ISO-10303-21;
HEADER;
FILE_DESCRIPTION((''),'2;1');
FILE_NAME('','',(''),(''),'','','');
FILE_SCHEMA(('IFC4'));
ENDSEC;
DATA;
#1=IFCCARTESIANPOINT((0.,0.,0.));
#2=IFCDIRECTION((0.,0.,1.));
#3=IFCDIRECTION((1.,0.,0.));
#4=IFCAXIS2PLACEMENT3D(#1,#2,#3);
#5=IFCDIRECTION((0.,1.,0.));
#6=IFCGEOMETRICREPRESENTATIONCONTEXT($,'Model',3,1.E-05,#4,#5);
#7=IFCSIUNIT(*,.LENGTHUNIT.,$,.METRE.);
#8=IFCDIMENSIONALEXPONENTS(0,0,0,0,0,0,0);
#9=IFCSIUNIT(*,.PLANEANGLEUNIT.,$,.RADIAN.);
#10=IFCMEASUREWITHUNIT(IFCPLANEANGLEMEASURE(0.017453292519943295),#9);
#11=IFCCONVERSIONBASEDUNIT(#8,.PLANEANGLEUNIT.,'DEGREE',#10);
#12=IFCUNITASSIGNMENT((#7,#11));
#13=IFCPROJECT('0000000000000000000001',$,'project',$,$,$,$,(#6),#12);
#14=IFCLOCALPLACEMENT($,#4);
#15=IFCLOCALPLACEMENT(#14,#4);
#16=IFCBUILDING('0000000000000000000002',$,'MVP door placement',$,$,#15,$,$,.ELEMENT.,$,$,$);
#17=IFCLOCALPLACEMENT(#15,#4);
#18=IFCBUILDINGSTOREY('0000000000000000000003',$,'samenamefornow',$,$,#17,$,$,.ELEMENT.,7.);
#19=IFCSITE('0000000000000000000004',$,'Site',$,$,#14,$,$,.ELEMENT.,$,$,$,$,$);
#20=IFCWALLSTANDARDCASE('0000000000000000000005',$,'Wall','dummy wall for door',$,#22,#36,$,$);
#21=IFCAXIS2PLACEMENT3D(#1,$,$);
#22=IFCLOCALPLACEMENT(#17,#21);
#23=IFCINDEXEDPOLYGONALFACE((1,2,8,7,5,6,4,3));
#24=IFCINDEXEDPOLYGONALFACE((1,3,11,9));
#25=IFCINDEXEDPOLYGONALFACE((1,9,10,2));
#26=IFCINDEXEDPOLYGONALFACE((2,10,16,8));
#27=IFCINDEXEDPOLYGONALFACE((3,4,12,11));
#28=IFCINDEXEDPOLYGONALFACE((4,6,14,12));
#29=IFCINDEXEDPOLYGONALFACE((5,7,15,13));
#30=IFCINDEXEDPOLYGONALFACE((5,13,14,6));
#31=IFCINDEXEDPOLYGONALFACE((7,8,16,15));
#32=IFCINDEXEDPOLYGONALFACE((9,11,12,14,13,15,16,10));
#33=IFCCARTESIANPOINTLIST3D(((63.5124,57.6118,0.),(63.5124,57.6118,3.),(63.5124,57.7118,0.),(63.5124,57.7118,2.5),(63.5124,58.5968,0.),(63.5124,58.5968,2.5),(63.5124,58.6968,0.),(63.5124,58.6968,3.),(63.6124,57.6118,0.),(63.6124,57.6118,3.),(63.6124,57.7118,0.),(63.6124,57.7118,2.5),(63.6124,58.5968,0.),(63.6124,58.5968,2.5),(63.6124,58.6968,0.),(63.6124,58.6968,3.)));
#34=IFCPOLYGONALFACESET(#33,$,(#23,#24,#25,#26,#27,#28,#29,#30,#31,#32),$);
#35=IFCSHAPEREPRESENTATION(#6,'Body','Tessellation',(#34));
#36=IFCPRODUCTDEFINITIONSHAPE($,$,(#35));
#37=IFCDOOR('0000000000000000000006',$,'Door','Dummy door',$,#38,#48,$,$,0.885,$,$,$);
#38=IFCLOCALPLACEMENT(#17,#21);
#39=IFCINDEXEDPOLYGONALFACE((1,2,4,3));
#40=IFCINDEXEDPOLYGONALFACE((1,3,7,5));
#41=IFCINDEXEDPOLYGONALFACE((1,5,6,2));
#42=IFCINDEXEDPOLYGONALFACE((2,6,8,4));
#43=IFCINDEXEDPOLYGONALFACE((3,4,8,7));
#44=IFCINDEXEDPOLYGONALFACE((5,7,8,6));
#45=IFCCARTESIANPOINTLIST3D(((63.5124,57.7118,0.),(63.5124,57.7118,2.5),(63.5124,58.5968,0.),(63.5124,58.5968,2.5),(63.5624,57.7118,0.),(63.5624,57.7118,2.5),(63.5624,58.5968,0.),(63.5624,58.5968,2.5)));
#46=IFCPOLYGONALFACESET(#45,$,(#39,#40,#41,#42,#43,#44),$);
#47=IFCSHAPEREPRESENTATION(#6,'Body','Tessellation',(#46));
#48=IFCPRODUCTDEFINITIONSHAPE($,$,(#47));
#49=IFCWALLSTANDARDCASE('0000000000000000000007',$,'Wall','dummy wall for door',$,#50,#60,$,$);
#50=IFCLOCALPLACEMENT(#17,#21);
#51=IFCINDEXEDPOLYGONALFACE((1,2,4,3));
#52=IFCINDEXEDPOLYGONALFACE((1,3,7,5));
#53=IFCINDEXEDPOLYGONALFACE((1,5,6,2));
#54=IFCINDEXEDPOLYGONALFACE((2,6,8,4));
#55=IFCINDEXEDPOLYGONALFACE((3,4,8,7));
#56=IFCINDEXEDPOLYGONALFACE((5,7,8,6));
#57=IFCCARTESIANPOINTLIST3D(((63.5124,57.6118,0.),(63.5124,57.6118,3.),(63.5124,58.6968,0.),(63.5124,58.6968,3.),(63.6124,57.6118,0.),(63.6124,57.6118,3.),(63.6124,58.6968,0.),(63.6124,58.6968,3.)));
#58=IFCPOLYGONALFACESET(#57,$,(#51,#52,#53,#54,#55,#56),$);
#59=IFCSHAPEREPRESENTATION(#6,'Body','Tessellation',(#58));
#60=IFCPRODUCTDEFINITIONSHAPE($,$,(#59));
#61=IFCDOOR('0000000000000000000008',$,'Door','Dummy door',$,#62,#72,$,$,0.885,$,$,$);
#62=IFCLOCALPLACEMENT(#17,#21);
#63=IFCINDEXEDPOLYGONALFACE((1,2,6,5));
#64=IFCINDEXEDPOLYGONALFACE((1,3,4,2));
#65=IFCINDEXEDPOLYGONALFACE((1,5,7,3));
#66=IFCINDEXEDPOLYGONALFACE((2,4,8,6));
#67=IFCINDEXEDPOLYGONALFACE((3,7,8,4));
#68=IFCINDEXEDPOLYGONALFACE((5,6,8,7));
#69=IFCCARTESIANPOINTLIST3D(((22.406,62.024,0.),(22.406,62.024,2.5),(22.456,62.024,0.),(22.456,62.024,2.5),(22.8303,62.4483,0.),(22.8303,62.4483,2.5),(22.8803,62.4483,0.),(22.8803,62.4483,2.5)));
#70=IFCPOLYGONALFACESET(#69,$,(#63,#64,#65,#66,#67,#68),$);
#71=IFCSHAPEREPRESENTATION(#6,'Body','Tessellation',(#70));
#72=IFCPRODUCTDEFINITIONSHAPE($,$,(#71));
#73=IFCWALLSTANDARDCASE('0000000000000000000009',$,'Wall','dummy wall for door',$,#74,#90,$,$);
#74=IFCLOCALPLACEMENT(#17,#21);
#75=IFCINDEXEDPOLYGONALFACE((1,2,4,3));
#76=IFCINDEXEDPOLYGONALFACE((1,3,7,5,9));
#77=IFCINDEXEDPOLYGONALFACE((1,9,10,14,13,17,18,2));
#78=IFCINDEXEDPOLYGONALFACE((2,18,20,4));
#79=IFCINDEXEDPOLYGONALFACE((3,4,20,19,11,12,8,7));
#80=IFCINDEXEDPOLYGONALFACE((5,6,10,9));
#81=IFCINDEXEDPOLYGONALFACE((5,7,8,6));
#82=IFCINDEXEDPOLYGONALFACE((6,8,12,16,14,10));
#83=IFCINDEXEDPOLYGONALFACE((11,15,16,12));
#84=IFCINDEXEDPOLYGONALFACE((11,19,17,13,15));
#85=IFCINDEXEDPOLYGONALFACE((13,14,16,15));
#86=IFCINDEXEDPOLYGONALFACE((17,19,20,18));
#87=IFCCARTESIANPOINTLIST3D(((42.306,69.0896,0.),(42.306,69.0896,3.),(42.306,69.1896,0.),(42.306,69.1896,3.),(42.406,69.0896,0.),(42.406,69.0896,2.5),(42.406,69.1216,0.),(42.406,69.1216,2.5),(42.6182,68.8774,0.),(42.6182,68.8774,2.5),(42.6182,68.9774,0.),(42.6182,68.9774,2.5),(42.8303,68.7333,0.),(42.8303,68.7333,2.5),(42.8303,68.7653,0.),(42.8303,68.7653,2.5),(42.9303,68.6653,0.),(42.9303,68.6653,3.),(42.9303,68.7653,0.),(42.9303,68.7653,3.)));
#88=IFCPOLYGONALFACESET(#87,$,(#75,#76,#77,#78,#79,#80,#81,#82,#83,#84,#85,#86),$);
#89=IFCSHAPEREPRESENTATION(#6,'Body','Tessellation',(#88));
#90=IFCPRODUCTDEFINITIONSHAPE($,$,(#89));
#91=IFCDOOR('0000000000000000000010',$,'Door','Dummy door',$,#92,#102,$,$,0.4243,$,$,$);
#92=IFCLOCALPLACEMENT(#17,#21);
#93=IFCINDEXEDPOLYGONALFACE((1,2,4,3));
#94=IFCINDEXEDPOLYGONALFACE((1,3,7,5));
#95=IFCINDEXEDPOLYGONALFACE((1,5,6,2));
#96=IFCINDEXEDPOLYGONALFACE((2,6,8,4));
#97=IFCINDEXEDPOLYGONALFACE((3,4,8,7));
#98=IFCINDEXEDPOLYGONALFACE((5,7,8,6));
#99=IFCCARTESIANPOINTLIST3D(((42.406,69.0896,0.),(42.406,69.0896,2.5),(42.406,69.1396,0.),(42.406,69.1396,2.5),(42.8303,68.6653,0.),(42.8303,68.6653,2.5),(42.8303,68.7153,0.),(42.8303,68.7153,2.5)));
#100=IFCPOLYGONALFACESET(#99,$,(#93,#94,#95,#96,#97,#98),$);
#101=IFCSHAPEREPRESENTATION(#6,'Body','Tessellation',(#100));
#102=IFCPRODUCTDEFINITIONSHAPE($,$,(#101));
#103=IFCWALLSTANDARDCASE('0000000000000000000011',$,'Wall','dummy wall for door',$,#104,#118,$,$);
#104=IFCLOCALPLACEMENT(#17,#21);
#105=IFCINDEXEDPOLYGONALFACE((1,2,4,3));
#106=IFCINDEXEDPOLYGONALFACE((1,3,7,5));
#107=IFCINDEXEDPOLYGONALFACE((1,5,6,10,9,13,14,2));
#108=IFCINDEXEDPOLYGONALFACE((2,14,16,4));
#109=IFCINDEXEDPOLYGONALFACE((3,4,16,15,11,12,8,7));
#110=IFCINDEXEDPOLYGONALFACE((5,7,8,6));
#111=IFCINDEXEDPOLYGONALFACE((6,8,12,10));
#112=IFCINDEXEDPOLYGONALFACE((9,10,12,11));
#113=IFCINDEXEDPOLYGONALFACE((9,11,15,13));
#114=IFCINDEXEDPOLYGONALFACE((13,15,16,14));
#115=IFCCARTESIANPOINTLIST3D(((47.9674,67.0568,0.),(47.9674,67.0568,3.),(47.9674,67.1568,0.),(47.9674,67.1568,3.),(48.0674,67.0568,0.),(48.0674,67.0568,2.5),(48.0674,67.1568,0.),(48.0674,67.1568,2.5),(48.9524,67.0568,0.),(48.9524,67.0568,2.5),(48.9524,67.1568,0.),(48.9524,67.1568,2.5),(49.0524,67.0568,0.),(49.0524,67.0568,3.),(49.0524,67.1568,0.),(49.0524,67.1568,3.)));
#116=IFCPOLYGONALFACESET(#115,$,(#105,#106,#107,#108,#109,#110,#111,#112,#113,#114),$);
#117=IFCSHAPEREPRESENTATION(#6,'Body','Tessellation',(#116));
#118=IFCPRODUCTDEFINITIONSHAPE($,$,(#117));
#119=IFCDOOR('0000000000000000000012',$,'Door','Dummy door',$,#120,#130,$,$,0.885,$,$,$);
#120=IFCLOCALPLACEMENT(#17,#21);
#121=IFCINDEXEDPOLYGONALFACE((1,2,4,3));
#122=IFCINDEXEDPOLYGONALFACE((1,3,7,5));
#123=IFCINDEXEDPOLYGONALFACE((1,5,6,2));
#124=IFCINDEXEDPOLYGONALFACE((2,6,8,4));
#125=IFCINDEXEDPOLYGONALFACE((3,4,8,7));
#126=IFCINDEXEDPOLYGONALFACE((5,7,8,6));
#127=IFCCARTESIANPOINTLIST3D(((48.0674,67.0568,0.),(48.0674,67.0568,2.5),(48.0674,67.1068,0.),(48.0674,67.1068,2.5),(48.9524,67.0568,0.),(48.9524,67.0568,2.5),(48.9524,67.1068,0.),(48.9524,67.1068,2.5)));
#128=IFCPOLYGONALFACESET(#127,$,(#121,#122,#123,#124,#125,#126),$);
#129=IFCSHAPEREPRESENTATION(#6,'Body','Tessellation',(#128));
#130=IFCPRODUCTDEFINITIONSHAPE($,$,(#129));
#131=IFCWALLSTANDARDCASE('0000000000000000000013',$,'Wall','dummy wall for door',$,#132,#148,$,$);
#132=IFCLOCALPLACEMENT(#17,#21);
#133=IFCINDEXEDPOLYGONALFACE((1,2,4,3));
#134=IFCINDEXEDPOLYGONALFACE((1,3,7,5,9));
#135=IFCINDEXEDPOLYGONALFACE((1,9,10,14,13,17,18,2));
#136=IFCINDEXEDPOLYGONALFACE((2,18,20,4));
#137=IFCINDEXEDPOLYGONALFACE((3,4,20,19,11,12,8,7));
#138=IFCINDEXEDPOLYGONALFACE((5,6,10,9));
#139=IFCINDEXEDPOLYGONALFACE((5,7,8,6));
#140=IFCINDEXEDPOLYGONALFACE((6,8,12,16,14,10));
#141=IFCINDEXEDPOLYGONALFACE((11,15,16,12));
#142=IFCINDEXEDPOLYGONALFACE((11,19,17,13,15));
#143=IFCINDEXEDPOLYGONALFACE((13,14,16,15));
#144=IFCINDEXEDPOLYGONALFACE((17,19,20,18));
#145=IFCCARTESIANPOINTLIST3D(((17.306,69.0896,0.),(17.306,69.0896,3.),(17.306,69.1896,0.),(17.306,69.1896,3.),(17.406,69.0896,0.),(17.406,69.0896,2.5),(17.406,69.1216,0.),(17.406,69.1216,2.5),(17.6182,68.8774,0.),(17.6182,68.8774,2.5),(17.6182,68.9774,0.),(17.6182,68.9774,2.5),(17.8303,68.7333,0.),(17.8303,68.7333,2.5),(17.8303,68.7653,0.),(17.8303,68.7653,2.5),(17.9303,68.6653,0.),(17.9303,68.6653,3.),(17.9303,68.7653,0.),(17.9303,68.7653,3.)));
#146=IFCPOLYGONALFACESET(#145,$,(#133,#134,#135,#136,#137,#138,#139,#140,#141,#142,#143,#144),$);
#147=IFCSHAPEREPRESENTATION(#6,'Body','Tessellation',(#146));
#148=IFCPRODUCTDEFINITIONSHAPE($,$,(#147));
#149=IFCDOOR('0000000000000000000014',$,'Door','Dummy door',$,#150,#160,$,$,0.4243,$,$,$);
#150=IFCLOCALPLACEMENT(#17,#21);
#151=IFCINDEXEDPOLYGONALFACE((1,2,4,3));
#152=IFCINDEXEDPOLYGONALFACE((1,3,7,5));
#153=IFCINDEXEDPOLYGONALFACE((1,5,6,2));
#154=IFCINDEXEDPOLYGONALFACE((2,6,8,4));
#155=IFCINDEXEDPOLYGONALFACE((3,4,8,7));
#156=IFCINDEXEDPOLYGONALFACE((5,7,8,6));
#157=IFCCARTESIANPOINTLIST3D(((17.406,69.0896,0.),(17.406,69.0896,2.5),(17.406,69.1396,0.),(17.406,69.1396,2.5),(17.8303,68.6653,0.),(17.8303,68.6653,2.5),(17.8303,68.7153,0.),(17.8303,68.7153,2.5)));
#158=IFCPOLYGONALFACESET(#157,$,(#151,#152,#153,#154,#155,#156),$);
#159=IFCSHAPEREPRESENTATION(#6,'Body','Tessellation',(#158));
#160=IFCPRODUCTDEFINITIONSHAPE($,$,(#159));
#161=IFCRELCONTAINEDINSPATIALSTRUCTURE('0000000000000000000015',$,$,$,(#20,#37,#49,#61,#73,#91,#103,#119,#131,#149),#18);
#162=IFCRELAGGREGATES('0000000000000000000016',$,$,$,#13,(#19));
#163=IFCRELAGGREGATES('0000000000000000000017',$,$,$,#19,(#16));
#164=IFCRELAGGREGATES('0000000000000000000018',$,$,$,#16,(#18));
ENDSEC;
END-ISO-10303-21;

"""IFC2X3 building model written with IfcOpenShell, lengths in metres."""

from ifc_helpers import new_model, entity, si_unit, converted_unit, direction, origin_with_axes, place, context, project, spatial, polyline, outline, extrude, element, fill, save


model = new_model("IFC2X3")

# Units and contexts
model_context = context("Model", 3, precision=1e-05, world=origin_with_axes(), true_north=direction((0.0, 1.0, 0.0)))
ifc_project = project(units=[si_unit("LENGTHUNIT", "METRE"), converted_unit("PLANEANGLEUNIT", "DEGREE", entity("IfcPlaneAngleMeasure", 0.017453292519943295), si_unit("PLANEANGLEUNIT", "RADIAN"), dimensions=[0, 0, 0, 0, 0, 0, 0])], contexts=[model_context])

# Site, building, storey
site_placement = place(None, origin_with_axes())
site = spatial("IfcSite", under=ifc_project, at=site_placement, Name="Site", CompositionType="ELEMENT")
building_placement = place(site_placement, origin_with_axes())
building = spatial("IfcBuilding", under=site, at=building_placement, Name="MVP door placement", CompositionType="ELEMENT")
storey_placement = place(building_placement, origin_with_axes())
storey = spatial("IfcBuildingStorey", under=building, at=storey_placement, Name="samenamefornow", CompositionType="ELEMENT", Elevation=7.0)

# Walls, openings, doors
wall_1_placement = place(storey_placement, origin_with_axes())
wall_1 = element("IfcWallStandardCase", 1, at=wall_1_placement, inside=storey, Name="Wall", Description="dummy wall for door", context=model_context, shape_type="SweptSolid", body=[
    extrude(outline(polyline([(63.5124, 57.6118, 0.0), (63.5124, 58.6968, 0.0), (63.6124, 58.6968, 0.0), (63.6124, 57.6118, 0.0), (63.5124, 57.6118, 0.0)])), origin_with_axes(), (0.0, 0.0, 1.0), 3.0),
])
opening_1_placement = place(wall_1_placement, origin_with_axes())
opening_1 = element("IfcOpeningElement", 2, at=opening_1_placement, cuts=wall_1, context=model_context, shape_type="SweptSolid", body=[
    extrude(outline(polyline([(63.5124, 57.7118, 0.0), (63.5124, 58.5968, 0.0), (63.6124, 58.5968, 0.0), (63.6124, 57.7118, 0.0), (63.5124, 57.7118, 0.0)])), origin_with_axes(), (0.0, 0.0, 1.0), 2.5),
])
door_1_placement = place(opening_1_placement, origin_with_axes())
door_1 = element("IfcDoor", 3, at=door_1_placement, inside=storey, Name="Door", Description="Dummy door", OverallWidth=0.885, context=model_context, shape_type="SweptSolid", body=[
    extrude(outline(polyline([(63.5124, 57.7118, 0.0), (63.5124, 58.5968, 0.0), (63.5624, 58.5968, 0.0), (63.5624, 57.7118, 0.0), (63.5124, 57.7118, 0.0)])), origin_with_axes(), (0.0, 0.0, 1.0), 2.5),
])
fill(opening_1, door_1)
wall_2_placement = place(storey_placement, origin_with_axes())
wall_2 = element("IfcWallStandardCase", 4, at=wall_2_placement, inside=storey, Name="Wall", Description="dummy wall for door", context=model_context, shape_type="SweptSolid", body=[
    extrude(outline(polyline([(63.5124, 57.6118, 0.0), (63.5124, 58.6968, 0.0), (63.6124, 58.6968, 0.0), (63.6124, 57.6118, 0.0), (63.5124, 57.6118, 0.0)])), origin_with_axes(), (0.0, 0.0, 1.0), 3.0),
])
opening_2_placement = place(wall_2_placement, origin_with_axes())
opening_2 = element("IfcOpeningElement", 5, at=opening_2_placement, cuts=wall_2, context=model_context, shape_type="SweptSolid", body=[
    extrude(outline(polyline([(22.406, 62.024, 0.0), (22.8303, 62.4483, 0.0), (22.9303, 62.4483, 0.0), (22.506, 62.024, 0.0), (22.406, 62.024, 0.0)])), origin_with_axes(), (0.0, 0.0, 1.0), 2.5),
])
door_2_placement = place(opening_2_placement, origin_with_axes())
door_2 = element("IfcDoor", 6, at=door_2_placement, inside=storey, Name="Door", Description="Dummy door", OverallWidth=0.885, context=model_context, shape_type="SweptSolid", body=[
    extrude(outline(polyline([(22.406, 62.024, 0.0), (22.8303, 62.4483, 0.0), (22.8803, 62.4483, 0.0), (22.456, 62.024, 0.0), (22.406, 62.024, 0.0)])), origin_with_axes(), (0.0, 0.0, 1.0), 2.5),
])
fill(opening_2, door_2)
wall_3_placement = place(storey_placement, origin_with_axes())
wall_3 = element("IfcWallStandardCase", 7, at=wall_3_placement, inside=storey, Name="Wall", Description="dummy wall for door", context=model_context, shape_type="SweptSolid", body=[
    extrude(outline(polyline([(42.306, 69.0896, 0.0), (42.9303, 68.6653, 0.0), (42.9303, 68.7653, 0.0), (42.306, 69.1896, 0.0), (42.306, 69.0896, 0.0)])), origin_with_axes(), (0.0, 0.0, 1.0), 3.0),
])
opening_3_placement = place(wall_3_placement, origin_with_axes())
opening_3 = element("IfcOpeningElement", 8, at=opening_3_placement, cuts=wall_3, context=model_context, shape_type="SweptSolid", body=[
    extrude(outline(polyline([(42.406, 69.0896, 0.0), (42.8303, 68.6653, 0.0), (42.8303, 68.7653, 0.0), (42.406, 69.1896, 0.0), (42.406, 69.0896, 0.0)])), origin_with_axes(), (0.0, 0.0, 1.0), 2.5),
])
door_3_placement = place(opening_3_placement, origin_with_axes())
door_3 = element("IfcDoor", 9, at=door_3_placement, inside=storey, Name="Door", Description="Dummy door", OverallWidth=0.4243, context=model_context, shape_type="SweptSolid", body=[
    extrude(outline(polyline([(42.406, 69.0896, 0.0), (42.8303, 68.6653, 0.0), (42.8303, 68.7153, 0.0), (42.406, 69.1396, 0.0), (42.406, 69.0896, 0.0)])), origin_with_axes(), (0.0, 0.0, 1.0), 2.5),
])
fill(opening_3, door_3)
wall_4_placement = place(storey_placement, origin_with_axes())
wall_4 = element("IfcWallStandardCase", 10, at=wall_4_placement, inside=storey, Name="Wall", Description="dummy wall for door", context=model_context, shape_type="SweptSolid", body=[
    extrude(outline(polyline([(47.9674, 67.0568, 0.0), (49.0524, 67.0568, 0.0), (49.0524, 67.1568, 0.0), (47.9674, 67.1568, 0.0), (47.9674, 67.0568, 0.0)])), origin_with_axes(), (0.0, 0.0, 1.0), 3.0),
])
opening_4_placement = place(wall_4_placement, origin_with_axes())
opening_4 = element("IfcOpeningElement", 11, at=opening_4_placement, cuts=wall_4, context=model_context, shape_type="SweptSolid", body=[
    extrude(outline(polyline([(48.0674, 67.0568, 0.0), (48.9524, 67.0568, 0.0), (48.9524, 67.1568, 0.0), (48.0674, 67.1568, 0.0), (48.0674, 67.0568, 0.0)])), origin_with_axes(), (0.0, 0.0, 1.0), 2.5),
])
door_4_placement = place(opening_4_placement, origin_with_axes())
door_4 = element("IfcDoor", 12, at=door_4_placement, inside=storey, Name="Door", Description="Dummy door", OverallWidth=0.885, context=model_context, shape_type="SweptSolid", body=[
    extrude(outline(polyline([(48.0674, 67.0568, 0.0), (48.9524, 67.0568, 0.0), (48.9524, 67.1068, 0.0), (48.0674, 67.1068, 0.0), (48.0674, 67.0568, 0.0)])), origin_with_axes(), (0.0, 0.0, 1.0), 2.5),
])
fill(opening_4, door_4)
wall_5_placement = place(storey_placement, origin_with_axes())
wall_5 = element("IfcWallStandardCase", 13, at=wall_5_placement, inside=storey, Name="Wall", Description="dummy wall for door", context=model_context, shape_type="SweptSolid", body=[
    extrude(outline(polyline([(17.306, 69.0896, 0.0), (17.9303, 68.6653, 0.0), (17.9303, 68.7653, 0.0), (17.306, 69.1896, 0.0), (17.306, 69.0896, 0.0)])), origin_with_axes(), (0.0, 0.0, 1.0), 3.0),
])
opening_5_placement = place(wall_5_placement, origin_with_axes())
opening_5 = element("IfcOpeningElement", 14, at=opening_5_placement, cuts=wall_5, context=model_context, shape_type="SweptSolid", body=[
    extrude(outline(polyline([(17.406, 69.0896, 0.0), (17.8303, 68.6653, 0.0), (17.8303, 68.7653, 0.0), (17.406, 69.1896, 0.0), (17.406, 69.0896, 0.0)])), origin_with_axes(), (0.0, 0.0, 1.0), 2.5),
])
door_5_placement = place(opening_5_placement, origin_with_axes())
door_5 = element("IfcDoor", 15, at=door_5_placement, inside=storey, Name="Door", Description="Dummy door", OverallWidth=0.4243, context=model_context, shape_type="SweptSolid", body=[
    extrude(outline(polyline([(17.406, 69.0896, 0.0), (17.8303, 68.6653, 0.0), (17.8303, 68.7153, 0.0), (17.406, 69.1396, 0.0), (17.406, 69.0896, 0.0)])), origin_with_axes(), (0.0, 0.0, 1.0), 2.5),
])
fill(opening_5, door_5)

save(model, "model.ifc")
